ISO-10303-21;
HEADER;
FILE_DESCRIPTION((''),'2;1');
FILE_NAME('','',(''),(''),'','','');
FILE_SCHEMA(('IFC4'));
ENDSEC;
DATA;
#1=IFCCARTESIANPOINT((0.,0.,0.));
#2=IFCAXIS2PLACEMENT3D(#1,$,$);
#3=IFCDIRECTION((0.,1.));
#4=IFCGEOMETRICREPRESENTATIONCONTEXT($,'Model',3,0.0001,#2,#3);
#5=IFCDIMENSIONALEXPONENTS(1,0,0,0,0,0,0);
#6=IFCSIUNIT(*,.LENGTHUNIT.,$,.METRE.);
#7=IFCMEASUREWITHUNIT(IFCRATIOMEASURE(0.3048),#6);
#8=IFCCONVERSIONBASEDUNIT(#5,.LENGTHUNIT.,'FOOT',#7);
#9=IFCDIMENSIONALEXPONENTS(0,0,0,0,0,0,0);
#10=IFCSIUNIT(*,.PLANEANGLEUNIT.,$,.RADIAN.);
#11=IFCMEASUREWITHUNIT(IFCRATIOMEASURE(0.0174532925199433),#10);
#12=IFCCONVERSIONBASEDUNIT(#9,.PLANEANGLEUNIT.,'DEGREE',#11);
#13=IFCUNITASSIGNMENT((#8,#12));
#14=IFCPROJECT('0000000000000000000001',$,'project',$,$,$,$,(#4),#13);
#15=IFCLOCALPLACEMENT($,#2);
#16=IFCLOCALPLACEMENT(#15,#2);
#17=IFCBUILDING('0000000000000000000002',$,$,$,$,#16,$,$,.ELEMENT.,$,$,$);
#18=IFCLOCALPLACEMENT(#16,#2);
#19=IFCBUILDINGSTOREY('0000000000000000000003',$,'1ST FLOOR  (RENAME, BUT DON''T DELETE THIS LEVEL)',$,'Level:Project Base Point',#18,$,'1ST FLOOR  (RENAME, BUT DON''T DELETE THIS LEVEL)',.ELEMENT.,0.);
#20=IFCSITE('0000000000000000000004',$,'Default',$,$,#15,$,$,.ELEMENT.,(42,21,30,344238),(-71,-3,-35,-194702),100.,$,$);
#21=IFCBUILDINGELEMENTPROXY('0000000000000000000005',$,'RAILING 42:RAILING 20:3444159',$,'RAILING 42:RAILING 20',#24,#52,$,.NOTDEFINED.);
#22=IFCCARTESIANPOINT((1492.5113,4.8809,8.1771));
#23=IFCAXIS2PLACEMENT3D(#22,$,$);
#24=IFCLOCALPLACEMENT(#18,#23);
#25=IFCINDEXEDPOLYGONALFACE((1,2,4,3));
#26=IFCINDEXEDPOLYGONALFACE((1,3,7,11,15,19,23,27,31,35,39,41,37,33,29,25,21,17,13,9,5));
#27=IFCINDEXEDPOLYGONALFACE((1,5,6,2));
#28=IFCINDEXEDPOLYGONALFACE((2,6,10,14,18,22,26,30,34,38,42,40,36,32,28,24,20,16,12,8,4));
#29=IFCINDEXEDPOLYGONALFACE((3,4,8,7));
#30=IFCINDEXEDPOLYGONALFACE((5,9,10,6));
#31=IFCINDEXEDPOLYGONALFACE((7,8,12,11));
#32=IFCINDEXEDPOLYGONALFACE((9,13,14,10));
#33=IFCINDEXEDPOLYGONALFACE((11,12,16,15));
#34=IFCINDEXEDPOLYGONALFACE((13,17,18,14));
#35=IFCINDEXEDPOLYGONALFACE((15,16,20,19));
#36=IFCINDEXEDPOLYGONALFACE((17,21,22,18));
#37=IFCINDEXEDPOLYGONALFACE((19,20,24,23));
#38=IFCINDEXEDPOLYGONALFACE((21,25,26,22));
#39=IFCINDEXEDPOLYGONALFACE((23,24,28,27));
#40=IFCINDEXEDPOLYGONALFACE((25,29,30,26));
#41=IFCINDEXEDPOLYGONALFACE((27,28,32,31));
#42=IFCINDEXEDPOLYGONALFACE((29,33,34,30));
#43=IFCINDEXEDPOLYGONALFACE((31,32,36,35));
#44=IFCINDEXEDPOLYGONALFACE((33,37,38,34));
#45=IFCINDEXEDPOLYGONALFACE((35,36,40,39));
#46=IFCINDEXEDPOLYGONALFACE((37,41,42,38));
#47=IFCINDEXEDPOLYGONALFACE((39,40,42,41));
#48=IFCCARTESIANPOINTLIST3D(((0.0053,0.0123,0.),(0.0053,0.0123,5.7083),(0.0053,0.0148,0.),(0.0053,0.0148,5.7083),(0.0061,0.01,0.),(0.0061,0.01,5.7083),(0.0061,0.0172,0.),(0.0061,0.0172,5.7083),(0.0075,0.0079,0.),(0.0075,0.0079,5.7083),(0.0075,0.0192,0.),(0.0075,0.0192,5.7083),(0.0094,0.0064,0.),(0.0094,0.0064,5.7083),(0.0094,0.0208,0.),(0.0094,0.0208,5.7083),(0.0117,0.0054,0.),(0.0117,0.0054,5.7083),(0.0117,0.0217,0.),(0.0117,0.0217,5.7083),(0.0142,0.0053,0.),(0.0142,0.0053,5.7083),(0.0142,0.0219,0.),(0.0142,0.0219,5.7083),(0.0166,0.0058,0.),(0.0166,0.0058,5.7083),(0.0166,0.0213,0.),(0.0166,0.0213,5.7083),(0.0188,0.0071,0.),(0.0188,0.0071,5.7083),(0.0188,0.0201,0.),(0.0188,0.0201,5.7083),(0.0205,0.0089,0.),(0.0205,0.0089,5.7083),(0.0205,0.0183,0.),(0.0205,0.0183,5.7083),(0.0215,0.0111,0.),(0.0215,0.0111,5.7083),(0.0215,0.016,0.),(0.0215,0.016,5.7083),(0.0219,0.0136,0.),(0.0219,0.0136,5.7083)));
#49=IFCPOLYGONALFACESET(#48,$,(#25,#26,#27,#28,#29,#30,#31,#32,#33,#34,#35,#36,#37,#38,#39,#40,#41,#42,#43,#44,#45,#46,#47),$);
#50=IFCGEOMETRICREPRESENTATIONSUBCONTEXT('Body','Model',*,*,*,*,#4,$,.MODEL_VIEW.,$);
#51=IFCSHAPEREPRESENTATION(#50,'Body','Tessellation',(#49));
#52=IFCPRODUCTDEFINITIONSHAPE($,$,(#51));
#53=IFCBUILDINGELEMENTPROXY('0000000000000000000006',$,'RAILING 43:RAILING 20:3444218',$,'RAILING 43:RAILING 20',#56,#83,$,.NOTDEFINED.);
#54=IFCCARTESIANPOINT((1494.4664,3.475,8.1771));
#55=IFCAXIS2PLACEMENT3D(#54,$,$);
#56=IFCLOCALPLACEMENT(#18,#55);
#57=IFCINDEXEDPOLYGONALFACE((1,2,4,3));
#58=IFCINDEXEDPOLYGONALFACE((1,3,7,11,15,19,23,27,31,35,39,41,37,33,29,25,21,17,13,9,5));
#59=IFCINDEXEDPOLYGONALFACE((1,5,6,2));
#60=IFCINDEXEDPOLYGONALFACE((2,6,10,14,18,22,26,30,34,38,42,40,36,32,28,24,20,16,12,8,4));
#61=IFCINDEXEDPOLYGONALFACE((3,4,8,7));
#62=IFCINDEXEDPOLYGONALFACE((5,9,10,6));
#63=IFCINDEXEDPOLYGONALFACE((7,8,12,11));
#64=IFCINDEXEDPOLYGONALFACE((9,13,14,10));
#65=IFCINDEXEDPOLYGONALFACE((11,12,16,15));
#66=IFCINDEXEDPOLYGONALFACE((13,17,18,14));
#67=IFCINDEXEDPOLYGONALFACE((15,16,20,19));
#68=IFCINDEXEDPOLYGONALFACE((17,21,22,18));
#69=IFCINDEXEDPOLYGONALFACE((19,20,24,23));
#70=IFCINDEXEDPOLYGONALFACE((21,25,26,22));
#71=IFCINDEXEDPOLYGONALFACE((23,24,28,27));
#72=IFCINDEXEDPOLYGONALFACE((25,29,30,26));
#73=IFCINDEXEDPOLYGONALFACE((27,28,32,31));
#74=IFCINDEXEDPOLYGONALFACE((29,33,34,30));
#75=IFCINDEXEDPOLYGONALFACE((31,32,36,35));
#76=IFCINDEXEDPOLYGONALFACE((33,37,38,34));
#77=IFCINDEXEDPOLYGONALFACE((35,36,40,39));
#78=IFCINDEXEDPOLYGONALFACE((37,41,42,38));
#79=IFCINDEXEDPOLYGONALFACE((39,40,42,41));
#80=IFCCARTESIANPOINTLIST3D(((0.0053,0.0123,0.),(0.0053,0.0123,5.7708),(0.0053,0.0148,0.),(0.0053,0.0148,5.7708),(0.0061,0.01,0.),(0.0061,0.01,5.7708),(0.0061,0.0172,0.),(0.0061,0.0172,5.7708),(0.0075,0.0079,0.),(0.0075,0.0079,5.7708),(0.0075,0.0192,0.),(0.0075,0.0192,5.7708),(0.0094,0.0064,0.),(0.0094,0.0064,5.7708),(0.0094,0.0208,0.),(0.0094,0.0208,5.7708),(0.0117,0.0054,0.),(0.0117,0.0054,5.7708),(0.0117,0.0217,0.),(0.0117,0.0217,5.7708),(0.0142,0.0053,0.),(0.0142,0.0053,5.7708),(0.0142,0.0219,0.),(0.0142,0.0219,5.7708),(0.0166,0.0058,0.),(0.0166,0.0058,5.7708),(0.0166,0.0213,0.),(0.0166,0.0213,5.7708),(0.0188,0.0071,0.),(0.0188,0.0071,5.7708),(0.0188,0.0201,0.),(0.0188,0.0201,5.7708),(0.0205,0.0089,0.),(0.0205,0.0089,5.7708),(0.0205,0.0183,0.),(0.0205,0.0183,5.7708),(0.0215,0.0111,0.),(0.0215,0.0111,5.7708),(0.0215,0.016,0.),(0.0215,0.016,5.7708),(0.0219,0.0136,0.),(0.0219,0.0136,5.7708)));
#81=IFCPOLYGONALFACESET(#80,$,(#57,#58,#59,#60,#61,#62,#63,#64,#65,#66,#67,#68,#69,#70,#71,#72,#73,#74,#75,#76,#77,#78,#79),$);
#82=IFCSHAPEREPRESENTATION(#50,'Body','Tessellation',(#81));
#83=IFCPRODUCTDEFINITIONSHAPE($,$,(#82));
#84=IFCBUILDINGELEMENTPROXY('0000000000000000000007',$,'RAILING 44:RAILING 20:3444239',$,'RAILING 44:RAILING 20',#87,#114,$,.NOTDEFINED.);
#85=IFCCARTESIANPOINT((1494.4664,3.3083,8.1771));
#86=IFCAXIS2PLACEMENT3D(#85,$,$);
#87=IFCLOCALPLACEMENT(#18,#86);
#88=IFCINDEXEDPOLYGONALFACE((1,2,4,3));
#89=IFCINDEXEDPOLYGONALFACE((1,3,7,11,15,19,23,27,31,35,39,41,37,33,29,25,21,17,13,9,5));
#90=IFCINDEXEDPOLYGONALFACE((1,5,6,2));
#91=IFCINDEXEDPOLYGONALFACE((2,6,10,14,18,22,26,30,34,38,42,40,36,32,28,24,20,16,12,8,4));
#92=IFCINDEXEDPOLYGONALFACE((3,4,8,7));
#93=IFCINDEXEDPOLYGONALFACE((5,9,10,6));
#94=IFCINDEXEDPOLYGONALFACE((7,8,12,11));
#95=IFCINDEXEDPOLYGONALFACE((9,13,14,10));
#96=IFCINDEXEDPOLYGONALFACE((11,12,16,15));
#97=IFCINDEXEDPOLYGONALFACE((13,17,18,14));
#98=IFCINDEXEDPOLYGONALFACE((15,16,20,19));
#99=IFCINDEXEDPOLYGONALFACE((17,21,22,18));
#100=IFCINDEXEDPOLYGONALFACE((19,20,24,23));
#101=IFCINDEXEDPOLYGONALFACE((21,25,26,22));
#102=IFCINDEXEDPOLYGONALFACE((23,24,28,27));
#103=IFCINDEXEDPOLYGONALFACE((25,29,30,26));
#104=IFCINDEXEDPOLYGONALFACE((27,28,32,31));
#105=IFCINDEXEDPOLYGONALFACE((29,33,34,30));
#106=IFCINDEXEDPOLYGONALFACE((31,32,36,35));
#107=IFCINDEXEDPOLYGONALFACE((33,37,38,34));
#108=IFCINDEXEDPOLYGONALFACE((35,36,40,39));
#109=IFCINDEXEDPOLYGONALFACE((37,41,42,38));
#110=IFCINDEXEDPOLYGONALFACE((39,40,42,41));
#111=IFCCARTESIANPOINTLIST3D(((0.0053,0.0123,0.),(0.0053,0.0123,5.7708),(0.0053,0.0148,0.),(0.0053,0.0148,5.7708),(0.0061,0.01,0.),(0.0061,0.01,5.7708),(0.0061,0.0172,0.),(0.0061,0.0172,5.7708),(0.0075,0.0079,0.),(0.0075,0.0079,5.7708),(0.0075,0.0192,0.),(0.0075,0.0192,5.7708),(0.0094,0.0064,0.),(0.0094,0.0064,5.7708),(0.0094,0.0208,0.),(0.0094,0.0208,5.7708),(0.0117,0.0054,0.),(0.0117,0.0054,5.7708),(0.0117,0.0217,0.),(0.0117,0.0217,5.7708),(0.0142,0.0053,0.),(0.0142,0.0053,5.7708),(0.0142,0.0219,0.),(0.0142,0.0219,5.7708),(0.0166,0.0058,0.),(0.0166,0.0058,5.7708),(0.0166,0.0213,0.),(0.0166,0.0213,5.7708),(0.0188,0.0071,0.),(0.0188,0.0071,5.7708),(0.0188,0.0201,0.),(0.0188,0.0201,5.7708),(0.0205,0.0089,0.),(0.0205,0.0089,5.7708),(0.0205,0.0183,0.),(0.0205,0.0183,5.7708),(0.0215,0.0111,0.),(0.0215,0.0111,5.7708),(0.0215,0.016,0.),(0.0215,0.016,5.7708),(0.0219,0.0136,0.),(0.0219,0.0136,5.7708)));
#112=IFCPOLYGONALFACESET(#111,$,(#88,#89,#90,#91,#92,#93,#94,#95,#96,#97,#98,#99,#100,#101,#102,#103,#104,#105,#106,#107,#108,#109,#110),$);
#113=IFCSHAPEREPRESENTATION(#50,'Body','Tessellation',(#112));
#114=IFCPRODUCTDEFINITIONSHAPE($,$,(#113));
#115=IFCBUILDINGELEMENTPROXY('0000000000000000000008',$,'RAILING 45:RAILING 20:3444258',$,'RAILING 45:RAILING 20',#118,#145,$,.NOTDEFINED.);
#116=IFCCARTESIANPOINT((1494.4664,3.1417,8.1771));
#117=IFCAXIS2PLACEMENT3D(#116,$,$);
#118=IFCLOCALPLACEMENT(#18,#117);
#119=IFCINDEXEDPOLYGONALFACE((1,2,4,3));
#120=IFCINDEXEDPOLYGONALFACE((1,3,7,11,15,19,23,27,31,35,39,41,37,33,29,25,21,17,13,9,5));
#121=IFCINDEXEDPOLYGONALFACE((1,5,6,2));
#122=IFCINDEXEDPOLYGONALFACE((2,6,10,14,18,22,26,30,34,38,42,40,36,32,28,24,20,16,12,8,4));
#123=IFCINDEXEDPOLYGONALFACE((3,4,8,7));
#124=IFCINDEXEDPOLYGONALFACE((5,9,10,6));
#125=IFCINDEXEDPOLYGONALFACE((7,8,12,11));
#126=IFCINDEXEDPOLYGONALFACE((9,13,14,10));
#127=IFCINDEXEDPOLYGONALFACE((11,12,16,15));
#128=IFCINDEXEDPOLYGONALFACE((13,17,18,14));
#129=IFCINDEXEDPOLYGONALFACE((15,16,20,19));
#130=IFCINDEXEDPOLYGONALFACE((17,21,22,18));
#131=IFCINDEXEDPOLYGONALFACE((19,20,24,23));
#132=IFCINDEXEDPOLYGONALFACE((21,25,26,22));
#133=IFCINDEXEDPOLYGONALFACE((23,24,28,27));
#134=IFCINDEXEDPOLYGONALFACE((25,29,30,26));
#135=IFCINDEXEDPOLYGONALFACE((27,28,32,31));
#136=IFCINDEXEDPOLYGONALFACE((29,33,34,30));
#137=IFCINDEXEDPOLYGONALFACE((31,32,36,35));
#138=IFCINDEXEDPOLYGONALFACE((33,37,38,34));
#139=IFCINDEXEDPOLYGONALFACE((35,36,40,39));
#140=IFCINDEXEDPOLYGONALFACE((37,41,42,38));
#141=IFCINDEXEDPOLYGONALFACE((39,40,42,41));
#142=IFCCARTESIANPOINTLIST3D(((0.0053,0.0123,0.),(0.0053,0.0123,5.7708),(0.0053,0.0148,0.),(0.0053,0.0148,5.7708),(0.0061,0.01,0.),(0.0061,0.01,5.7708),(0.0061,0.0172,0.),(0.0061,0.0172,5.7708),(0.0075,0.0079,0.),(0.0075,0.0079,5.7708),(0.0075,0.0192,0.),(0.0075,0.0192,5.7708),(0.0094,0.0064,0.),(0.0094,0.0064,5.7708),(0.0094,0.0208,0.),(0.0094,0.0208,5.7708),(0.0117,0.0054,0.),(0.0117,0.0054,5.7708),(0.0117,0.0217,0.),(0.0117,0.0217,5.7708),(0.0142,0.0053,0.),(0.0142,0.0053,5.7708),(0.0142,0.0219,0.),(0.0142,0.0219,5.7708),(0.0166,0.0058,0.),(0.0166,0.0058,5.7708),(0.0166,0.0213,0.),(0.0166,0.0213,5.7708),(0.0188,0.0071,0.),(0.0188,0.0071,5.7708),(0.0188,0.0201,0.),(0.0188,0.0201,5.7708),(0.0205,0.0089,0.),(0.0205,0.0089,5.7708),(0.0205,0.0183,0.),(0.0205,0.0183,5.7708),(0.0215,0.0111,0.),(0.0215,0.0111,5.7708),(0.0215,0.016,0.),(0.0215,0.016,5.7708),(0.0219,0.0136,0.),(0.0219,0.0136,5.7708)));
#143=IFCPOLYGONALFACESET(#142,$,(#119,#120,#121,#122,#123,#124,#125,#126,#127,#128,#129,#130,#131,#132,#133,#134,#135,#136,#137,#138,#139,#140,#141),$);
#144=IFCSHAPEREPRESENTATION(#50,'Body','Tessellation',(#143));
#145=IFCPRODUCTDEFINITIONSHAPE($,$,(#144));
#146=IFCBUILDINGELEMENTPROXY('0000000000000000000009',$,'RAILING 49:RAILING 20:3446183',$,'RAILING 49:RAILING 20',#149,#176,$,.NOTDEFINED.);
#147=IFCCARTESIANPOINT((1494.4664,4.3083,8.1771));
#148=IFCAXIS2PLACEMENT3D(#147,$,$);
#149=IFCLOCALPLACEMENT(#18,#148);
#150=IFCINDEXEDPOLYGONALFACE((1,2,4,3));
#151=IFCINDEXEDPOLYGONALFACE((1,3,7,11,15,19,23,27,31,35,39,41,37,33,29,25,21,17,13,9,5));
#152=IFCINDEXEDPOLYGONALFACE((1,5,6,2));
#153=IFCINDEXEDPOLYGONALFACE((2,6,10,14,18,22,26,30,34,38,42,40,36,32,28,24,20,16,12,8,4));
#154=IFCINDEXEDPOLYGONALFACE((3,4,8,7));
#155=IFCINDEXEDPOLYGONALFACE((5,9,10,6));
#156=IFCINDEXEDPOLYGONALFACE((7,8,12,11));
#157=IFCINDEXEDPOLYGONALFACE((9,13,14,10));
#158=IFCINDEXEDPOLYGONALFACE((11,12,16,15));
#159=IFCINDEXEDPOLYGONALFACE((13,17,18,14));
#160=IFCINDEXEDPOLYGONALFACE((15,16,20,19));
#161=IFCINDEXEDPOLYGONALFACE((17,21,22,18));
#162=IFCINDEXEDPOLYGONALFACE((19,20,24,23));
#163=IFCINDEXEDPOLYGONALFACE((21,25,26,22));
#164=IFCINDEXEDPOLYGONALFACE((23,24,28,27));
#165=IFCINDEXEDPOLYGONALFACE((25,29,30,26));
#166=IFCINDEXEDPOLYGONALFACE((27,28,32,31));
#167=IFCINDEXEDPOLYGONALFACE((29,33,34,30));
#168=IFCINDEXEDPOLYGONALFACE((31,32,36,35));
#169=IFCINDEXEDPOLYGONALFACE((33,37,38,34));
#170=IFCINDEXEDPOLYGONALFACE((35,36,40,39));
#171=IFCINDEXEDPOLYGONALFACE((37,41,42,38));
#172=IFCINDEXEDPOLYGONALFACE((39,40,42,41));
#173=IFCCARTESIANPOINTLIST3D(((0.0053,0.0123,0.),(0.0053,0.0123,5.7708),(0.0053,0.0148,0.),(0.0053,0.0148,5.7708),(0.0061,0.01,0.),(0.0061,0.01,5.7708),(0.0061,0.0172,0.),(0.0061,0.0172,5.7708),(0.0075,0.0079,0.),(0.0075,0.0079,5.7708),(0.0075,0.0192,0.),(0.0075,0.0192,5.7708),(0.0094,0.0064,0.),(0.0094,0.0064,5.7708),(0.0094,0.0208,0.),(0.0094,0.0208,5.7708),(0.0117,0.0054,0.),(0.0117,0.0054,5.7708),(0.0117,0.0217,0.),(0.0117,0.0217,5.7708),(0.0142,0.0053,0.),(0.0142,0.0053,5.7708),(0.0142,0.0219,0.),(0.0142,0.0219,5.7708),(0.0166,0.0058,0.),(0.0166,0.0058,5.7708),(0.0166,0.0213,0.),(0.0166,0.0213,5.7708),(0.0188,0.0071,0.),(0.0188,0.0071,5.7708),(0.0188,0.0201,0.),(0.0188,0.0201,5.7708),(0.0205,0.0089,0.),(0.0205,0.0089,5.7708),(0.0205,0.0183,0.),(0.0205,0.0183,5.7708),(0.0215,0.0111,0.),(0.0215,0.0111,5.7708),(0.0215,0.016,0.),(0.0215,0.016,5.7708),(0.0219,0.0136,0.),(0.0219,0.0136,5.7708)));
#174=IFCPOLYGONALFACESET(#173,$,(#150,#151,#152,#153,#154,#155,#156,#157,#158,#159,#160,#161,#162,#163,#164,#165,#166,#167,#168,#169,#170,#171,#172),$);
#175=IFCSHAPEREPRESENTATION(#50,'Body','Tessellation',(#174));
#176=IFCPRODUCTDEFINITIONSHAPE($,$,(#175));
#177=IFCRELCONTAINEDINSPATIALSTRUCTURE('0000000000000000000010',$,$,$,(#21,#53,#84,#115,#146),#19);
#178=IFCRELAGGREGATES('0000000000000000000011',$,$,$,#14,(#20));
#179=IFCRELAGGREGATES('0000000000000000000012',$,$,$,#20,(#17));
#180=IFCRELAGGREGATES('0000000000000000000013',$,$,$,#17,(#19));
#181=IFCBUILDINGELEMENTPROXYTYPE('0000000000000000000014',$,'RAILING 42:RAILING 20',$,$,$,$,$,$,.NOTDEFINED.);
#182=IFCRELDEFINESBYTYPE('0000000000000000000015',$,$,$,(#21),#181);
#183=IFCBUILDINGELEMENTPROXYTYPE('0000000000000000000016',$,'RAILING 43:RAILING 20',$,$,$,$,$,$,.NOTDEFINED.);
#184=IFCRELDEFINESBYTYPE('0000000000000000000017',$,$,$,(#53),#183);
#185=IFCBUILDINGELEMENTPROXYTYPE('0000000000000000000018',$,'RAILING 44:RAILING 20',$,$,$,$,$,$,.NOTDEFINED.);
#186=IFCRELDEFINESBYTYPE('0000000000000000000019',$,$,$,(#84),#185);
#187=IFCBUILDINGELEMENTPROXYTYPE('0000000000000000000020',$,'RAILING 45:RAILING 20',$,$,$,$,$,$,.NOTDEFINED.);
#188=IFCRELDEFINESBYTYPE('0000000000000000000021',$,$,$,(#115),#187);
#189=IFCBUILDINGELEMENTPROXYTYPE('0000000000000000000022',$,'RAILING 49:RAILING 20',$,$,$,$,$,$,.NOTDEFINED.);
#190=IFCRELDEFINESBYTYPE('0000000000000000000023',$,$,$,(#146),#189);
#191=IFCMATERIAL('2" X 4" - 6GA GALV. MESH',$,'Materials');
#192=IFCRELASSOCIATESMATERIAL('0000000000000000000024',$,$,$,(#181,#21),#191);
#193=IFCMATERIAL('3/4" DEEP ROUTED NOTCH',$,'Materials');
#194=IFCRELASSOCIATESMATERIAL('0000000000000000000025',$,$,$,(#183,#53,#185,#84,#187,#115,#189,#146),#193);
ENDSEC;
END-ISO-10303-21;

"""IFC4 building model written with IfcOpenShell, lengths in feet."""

from ifc_helpers import new_model, entity, si_unit, converted_unit, direction, frame, origin, origin_2d_with_axis, place, context, subcontext, project, spatial, circle, extrude, source, transform, mapped, material, type_object, type_shapes, element, save


model = new_model("IFC4")

# Units and contexts
model_context = context("Model", 3, precision=0.0001, world=origin(), true_north=direction((0.0, 1.0)))
body_context = subcontext(model_context, "Body", "Model", "MODEL_VIEW")
ifc_project = project(units=[converted_unit("LENGTHUNIT", "FOOT", entity("IfcRatioMeasure", 0.3048), si_unit("LENGTHUNIT", "METRE"), dimensions=[1, 0, 0, 0, 0, 0, 0]), converted_unit("PLANEANGLEUNIT", "DEGREE", entity("IfcRatioMeasure", 0.0174532925199433), si_unit("PLANEANGLEUNIT", "RADIAN"), dimensions=[0, 0, 0, 0, 0, 0, 0])], contexts=[model_context])

# Site, building, storey
site_placement = place(None, origin())
site = spatial("IfcSite", under=ifc_project, at=site_placement, Name="Default", CompositionType="ELEMENT", RefLatitude=(42, 21, 30, 344238), RefLongitude=(-71, -3, -35, -194702), RefElevation=100.0)
building_placement = place(site_placement, origin())
building = spatial("IfcBuilding", under=site, at=building_placement, CompositionType="ELEMENT")
storey_placement = place(building_placement, origin())
storey = spatial("IfcBuildingStorey", under=building, at=storey_placement, Name="1ST FLOOR  (RENAME, BUT DON'T DELETE THIS LEVEL)", ObjectType="Level:Project Base Point", LongName="1ST FLOOR  (RENAME, BUT DON'T DELETE THIS LEVEL)", CompositionType="ELEMENT", Elevation=0.0)

# Building element proxies
ifc_material_1 = material(Name="2\" X 4\" - 6GA GALV. MESH", Category="Materials")
ifc_material_2 = material(Name="3/4\" DEEP ROUTED NOTCH", Category="Materials")
building_element_proxy_type_1 = type_object("IfcBuildingElementProxyType", Name="RAILING 42:RAILING 20", PredefinedType="NOTDEFINED", material=ifc_material_1)
shared_shape_1 = source(origin(), body_context, "Body", "SweptSolid", [
    extrude(circle(Radius=0.0083, at=origin_2d_with_axis()), frame((0.0136, 0.0136, 0.0)), (0.0, 0.0, 1.0), 5.7083),
])
type_shapes(building_element_proxy_type_1, [shared_shape_1])
proxy_1_placement = place(storey_placement, frame((1492.5113, 4.8809, 8.1771)))
element("IfcBuildingElementProxy", 1, at=proxy_1_placement, inside=storey, type_object=building_element_proxy_type_1, material=ifc_material_1, Name="RAILING 42:RAILING 20:3444159", ObjectType="RAILING 42:RAILING 20", PredefinedType="NOTDEFINED", context=body_context, shape_type="MappedRepresentation", body=[
    mapped(shared_shape_1, transform((0.0, 0.0, 0.0), scale=1.0)),
])
building_element_proxy_type_2 = type_object("IfcBuildingElementProxyType", Name="RAILING 43:RAILING 20", PredefinedType="NOTDEFINED", material=ifc_material_2)
shared_shape_2 = source(origin(), body_context, "Body", "SweptSolid", [
    extrude(circle(Radius=0.0083, at=origin_2d_with_axis()), frame((0.0136, 0.0136, 0.0)), (0.0, 0.0, 1.0), 5.7708),
])
type_shapes(building_element_proxy_type_2, [shared_shape_2])
proxy_2_placement = place(storey_placement, frame((1494.4664, 3.475, 8.1771)))
element("IfcBuildingElementProxy", 2, at=proxy_2_placement, inside=storey, type_object=building_element_proxy_type_2, material=ifc_material_2, Name="RAILING 43:RAILING 20:3444218", ObjectType="RAILING 43:RAILING 20", PredefinedType="NOTDEFINED", context=body_context, shape_type="MappedRepresentation", body=[
    mapped(shared_shape_2, transform((0.0, 0.0, 0.0), scale=1.0)),
])
building_element_proxy_type_3 = type_object("IfcBuildingElementProxyType", Name="RAILING 44:RAILING 20", PredefinedType="NOTDEFINED", material=ifc_material_2)
shared_shape_3 = source(origin(), body_context, "Body", "SweptSolid", [
    extrude(circle(Radius=0.0083, at=origin_2d_with_axis()), frame((0.0136, 0.0136, 0.0)), (0.0, 0.0, 1.0), 5.7708),
])
type_shapes(building_element_proxy_type_3, [shared_shape_3])
proxy_3_placement = place(storey_placement, frame((1494.4664, 3.3083, 8.1771)))
element("IfcBuildingElementProxy", 3, at=proxy_3_placement, inside=storey, type_object=building_element_proxy_type_3, material=ifc_material_2, Name="RAILING 44:RAILING 20:3444239", ObjectType="RAILING 44:RAILING 20", PredefinedType="NOTDEFINED", context=body_context, shape_type="MappedRepresentation", body=[
    mapped(shared_shape_3, transform((0.0, 0.0, 0.0), scale=1.0)),
])
building_element_proxy_type_4 = type_object("IfcBuildingElementProxyType", Name="RAILING 45:RAILING 20", PredefinedType="NOTDEFINED", material=ifc_material_2)
shared_shape_4 = source(origin(), body_context, "Body", "SweptSolid", [
    extrude(circle(Radius=0.0083, at=origin_2d_with_axis()), frame((0.0136, 0.0136, 0.0)), (0.0, 0.0, 1.0), 5.7708),
])
type_shapes(building_element_proxy_type_4, [shared_shape_4])
proxy_4_placement = place(storey_placement, frame((1494.4664, 3.1417, 8.1771)))
element("IfcBuildingElementProxy", 4, at=proxy_4_placement, inside=storey, type_object=building_element_proxy_type_4, material=ifc_material_2, Name="RAILING 45:RAILING 20:3444258", ObjectType="RAILING 45:RAILING 20", PredefinedType="NOTDEFINED", context=body_context, shape_type="MappedRepresentation", body=[
    mapped(shared_shape_4, transform((0.0, 0.0, 0.0), scale=1.0)),
])
building_element_proxy_type_5 = type_object("IfcBuildingElementProxyType", Name="RAILING 49:RAILING 20", PredefinedType="NOTDEFINED", material=ifc_material_2)
shared_shape_5 = source(origin(), body_context, "Body", "SweptSolid", [
    extrude(circle(Radius=0.0083, at=origin_2d_with_axis()), frame((0.0136, 0.0136, 0.0)), (0.0, 0.0, 1.0), 5.7708),
])
type_shapes(building_element_proxy_type_5, [shared_shape_5])
proxy_5_placement = place(storey_placement, frame((1494.4664, 4.3083, 8.1771)))
element("IfcBuildingElementProxy", 5, at=proxy_5_placement, inside=storey, type_object=building_element_proxy_type_5, material=ifc_material_2, Name="RAILING 49:RAILING 20:3446183", ObjectType="RAILING 49:RAILING 20", PredefinedType="NOTDEFINED", context=body_context, shape_type="MappedRepresentation", body=[
    mapped(shared_shape_5, transform((0.0, 0.0, 0.0), scale=1.0)),
])

save(model, "model.ifc")
